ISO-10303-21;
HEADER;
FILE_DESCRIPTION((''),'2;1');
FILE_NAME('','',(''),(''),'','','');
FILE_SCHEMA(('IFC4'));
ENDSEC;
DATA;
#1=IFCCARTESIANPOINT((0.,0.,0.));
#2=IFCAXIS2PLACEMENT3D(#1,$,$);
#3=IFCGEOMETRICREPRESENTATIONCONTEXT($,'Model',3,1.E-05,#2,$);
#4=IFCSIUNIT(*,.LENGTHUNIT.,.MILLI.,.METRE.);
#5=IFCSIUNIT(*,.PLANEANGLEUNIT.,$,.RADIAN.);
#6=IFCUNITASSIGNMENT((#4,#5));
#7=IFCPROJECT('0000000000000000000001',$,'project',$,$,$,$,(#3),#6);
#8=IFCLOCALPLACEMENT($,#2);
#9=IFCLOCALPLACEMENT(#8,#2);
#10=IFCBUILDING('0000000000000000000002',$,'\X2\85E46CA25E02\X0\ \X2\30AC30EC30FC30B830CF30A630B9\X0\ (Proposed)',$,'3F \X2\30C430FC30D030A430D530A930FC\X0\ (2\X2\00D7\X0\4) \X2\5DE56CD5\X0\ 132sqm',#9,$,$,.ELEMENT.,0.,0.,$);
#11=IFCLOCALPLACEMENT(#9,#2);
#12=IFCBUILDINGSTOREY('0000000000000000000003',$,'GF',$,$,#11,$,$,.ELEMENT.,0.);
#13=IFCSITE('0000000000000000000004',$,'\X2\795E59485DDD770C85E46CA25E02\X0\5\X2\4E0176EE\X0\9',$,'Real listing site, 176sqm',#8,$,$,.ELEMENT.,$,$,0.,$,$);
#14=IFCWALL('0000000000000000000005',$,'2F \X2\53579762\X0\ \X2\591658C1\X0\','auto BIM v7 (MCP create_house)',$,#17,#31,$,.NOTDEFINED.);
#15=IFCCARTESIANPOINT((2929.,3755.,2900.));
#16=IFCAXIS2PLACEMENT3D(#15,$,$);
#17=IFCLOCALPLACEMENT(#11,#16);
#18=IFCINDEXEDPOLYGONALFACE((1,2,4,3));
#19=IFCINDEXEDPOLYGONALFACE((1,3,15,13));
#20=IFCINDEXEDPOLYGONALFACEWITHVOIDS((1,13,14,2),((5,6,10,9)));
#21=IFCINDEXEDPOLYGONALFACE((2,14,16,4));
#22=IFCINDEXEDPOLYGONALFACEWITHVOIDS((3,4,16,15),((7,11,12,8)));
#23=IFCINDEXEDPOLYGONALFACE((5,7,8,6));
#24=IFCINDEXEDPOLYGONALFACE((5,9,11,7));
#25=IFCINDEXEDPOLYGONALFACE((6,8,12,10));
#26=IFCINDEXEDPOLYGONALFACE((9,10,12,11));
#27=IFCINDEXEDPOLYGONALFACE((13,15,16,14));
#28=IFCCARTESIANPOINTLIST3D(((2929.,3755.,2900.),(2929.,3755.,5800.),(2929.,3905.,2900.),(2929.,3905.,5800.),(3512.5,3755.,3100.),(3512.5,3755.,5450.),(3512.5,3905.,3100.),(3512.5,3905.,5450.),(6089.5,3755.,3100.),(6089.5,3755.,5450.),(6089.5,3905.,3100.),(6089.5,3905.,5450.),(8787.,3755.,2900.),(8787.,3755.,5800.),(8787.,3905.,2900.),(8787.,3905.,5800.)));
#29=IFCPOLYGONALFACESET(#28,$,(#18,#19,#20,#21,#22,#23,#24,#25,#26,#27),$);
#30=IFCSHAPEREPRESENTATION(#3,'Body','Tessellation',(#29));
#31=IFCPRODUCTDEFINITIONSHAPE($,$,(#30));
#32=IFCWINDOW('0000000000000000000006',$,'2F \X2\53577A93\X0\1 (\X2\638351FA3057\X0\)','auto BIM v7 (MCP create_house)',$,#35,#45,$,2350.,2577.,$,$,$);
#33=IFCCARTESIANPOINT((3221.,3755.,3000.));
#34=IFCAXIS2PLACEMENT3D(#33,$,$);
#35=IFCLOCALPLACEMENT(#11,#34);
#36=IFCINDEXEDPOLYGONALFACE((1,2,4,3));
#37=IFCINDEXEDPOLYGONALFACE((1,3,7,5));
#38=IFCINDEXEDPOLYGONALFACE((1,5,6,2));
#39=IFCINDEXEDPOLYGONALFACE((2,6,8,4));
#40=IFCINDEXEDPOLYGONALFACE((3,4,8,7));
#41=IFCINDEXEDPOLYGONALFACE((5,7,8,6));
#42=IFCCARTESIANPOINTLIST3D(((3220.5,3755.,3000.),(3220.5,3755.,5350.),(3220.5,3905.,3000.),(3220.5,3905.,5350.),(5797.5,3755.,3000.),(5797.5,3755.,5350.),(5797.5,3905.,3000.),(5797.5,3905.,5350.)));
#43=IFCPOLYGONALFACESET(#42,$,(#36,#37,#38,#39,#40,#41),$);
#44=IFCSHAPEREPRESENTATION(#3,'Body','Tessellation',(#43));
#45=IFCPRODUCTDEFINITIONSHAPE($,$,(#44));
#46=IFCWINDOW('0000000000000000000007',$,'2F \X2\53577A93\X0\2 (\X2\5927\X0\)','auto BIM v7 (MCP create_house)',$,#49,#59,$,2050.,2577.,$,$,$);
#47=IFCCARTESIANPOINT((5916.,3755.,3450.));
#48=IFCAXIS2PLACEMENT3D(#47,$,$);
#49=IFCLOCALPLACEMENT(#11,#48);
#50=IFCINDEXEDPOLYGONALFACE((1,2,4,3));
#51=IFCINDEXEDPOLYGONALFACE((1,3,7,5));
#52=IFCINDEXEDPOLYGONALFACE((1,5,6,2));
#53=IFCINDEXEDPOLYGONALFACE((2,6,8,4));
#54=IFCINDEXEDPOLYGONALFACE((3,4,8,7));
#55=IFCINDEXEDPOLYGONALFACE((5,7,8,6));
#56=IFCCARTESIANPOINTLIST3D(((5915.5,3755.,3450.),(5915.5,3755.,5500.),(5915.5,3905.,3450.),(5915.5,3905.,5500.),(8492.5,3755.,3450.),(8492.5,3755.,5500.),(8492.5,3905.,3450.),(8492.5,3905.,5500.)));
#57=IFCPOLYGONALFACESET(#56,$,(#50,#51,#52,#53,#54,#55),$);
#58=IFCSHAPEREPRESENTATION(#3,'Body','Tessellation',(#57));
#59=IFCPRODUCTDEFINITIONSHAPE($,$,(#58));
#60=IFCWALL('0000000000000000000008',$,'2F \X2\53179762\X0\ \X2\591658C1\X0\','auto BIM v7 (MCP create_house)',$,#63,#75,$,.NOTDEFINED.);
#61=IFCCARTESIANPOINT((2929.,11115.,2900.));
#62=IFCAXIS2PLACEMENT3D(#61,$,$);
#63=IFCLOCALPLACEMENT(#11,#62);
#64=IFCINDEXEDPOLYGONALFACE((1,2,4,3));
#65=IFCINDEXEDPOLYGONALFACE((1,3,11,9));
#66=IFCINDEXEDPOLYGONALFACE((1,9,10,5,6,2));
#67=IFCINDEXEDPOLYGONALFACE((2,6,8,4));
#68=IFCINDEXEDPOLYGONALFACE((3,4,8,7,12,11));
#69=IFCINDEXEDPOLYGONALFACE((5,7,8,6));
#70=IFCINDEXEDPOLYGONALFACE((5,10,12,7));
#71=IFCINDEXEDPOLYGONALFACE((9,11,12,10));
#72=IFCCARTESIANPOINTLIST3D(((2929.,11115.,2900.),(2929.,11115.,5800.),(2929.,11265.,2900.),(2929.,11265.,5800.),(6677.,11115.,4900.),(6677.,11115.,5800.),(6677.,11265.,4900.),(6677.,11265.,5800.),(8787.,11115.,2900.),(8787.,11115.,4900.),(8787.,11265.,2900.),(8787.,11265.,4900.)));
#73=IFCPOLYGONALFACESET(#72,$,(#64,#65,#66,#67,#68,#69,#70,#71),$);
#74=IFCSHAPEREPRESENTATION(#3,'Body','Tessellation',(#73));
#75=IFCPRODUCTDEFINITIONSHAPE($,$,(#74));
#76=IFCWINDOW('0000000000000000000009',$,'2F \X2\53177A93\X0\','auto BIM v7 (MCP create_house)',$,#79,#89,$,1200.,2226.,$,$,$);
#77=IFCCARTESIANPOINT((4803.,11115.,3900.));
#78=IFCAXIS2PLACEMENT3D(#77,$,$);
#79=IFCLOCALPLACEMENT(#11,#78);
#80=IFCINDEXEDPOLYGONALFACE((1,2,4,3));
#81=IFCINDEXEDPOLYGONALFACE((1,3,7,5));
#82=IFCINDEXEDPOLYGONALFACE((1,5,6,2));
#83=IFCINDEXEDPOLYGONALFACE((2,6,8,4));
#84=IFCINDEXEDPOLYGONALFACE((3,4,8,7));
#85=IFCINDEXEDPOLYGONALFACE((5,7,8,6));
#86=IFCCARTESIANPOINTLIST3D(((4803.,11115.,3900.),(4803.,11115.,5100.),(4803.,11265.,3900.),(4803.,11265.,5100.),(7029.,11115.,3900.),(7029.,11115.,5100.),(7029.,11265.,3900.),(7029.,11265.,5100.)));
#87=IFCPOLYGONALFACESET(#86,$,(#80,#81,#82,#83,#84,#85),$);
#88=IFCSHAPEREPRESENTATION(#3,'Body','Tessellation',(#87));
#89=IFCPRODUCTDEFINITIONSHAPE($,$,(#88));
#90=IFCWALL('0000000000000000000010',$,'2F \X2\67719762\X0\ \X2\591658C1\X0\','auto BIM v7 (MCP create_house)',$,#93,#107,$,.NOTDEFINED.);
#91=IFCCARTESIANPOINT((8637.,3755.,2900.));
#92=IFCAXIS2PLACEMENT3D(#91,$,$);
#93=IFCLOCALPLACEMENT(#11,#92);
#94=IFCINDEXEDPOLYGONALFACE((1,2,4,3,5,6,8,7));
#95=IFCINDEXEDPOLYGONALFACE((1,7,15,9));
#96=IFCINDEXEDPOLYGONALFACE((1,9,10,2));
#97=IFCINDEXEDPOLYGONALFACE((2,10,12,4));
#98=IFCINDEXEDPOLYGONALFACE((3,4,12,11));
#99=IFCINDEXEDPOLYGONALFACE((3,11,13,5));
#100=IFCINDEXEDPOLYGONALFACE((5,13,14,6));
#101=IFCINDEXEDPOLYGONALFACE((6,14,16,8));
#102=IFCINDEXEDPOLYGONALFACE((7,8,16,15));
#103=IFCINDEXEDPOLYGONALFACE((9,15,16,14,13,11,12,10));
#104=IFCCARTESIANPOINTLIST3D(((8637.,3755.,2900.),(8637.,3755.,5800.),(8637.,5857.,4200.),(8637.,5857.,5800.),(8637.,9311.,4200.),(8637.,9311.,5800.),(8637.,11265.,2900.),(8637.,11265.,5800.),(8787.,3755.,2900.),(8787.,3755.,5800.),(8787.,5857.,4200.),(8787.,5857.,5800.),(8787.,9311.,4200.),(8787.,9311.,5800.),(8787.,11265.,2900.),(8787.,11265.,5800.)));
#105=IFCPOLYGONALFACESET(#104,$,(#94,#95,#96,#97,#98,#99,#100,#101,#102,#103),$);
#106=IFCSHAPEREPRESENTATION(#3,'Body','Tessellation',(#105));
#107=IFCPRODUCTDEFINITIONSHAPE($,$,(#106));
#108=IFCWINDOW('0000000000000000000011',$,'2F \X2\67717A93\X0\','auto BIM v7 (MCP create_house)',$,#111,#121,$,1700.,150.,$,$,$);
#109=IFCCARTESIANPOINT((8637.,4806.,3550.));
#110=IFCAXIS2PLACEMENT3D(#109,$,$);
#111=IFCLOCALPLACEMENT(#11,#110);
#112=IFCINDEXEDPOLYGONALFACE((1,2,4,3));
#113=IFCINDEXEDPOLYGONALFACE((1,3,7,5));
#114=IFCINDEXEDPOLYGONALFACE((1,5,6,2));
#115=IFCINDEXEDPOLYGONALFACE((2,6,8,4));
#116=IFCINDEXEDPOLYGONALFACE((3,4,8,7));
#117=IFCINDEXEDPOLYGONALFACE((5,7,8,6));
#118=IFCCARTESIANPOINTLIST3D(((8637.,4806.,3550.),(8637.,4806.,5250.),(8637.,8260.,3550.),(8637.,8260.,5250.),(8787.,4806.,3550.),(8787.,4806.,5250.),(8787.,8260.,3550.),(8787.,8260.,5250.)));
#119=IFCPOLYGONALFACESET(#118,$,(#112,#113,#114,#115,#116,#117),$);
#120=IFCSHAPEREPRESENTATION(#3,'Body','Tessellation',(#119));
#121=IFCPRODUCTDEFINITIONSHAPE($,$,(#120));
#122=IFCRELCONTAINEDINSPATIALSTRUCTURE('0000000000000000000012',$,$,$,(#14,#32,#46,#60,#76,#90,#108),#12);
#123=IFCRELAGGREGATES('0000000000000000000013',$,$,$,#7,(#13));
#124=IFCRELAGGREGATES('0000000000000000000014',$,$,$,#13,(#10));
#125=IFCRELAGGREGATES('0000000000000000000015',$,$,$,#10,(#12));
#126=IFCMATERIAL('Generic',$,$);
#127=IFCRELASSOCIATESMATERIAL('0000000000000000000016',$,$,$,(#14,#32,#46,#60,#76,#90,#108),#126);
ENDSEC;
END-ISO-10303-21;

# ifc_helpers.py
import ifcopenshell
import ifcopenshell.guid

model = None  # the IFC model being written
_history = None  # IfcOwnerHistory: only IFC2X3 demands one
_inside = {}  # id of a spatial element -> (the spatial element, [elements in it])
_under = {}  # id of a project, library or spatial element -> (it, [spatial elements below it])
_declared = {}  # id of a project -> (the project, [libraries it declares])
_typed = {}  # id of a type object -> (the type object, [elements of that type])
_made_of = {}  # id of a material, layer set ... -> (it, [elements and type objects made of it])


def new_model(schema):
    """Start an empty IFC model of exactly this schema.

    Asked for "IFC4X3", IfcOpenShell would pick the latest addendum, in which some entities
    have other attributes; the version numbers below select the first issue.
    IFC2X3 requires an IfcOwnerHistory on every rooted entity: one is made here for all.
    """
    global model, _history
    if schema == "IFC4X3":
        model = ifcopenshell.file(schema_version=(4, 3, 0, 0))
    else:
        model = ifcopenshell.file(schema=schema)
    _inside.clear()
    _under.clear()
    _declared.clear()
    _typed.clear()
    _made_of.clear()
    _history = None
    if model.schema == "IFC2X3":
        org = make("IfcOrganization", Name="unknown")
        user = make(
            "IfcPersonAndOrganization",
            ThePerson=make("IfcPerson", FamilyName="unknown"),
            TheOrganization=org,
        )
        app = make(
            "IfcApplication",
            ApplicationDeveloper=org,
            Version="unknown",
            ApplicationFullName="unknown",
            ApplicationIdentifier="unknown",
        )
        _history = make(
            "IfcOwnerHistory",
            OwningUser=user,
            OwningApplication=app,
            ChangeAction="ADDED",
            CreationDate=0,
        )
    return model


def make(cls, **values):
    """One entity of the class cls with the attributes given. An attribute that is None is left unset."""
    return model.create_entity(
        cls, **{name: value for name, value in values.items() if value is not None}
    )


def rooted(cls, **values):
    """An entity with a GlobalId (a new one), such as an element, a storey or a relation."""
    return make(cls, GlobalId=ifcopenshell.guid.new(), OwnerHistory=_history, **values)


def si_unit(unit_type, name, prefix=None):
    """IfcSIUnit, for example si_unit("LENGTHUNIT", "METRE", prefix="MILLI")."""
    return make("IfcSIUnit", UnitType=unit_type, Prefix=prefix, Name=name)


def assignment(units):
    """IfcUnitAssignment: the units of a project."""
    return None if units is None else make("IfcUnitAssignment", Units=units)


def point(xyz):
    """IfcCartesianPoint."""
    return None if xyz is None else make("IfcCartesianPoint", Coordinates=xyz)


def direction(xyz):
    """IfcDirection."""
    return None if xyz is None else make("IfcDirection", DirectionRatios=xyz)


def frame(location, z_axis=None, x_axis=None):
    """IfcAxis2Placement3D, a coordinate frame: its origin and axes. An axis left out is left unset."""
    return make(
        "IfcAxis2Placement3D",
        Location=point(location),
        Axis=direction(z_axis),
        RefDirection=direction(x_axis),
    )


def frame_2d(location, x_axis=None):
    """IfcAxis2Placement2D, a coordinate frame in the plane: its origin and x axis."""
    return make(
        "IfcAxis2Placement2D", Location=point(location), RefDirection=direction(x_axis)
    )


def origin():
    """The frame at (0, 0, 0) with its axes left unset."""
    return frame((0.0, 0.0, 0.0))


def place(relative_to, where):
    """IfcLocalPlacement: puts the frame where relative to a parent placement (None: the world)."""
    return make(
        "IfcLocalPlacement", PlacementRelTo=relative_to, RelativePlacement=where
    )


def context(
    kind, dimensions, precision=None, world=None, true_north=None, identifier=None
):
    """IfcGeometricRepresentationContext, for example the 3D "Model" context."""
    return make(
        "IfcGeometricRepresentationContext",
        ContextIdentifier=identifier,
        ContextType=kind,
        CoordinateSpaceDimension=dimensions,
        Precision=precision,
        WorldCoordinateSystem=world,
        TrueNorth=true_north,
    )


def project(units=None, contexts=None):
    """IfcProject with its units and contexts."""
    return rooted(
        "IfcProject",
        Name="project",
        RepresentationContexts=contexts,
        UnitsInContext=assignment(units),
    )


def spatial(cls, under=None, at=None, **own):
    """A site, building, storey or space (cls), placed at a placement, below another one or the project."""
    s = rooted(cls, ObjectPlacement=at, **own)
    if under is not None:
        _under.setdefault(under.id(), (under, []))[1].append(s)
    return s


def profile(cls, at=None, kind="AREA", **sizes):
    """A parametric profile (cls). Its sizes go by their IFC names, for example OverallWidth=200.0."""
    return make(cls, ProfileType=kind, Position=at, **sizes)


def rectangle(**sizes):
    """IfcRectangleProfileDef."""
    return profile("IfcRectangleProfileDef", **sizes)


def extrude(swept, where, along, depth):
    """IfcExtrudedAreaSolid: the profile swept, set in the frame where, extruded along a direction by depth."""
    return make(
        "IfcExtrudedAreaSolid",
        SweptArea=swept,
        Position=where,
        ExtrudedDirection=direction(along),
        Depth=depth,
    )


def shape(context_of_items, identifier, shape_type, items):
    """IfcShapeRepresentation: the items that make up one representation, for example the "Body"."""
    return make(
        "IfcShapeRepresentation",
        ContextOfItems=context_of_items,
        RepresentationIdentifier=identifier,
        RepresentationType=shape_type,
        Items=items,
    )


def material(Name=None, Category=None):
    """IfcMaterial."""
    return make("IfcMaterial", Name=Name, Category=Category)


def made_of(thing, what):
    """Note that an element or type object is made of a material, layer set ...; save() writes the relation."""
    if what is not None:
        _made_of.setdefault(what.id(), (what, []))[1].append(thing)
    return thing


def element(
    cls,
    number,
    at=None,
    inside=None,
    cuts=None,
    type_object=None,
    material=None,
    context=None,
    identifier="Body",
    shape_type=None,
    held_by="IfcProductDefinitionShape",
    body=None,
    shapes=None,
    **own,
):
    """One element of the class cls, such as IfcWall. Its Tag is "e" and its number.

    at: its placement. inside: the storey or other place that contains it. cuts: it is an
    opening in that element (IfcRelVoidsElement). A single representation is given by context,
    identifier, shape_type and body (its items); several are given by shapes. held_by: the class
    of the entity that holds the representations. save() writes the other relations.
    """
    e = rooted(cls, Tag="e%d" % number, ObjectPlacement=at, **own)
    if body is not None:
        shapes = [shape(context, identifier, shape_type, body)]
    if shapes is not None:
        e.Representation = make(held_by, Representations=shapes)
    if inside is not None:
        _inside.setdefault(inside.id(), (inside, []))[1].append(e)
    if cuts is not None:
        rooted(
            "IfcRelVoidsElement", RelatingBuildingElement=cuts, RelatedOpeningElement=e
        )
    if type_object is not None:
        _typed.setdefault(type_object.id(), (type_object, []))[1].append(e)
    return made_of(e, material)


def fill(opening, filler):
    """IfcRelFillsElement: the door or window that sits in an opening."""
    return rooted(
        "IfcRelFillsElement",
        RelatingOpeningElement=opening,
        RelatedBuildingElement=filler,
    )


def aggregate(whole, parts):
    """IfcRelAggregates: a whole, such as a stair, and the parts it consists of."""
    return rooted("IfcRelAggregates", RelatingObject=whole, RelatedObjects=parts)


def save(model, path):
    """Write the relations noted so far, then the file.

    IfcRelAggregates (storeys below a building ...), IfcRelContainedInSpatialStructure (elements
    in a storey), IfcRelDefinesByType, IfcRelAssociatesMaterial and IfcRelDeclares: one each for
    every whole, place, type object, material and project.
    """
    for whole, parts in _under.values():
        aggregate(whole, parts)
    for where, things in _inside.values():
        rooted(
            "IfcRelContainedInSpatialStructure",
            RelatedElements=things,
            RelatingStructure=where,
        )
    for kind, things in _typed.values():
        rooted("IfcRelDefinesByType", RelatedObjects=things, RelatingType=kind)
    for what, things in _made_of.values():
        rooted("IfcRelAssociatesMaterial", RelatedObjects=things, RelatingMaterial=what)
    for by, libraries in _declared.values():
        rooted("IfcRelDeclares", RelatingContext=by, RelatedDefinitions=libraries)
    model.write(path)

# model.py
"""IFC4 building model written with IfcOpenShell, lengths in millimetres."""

from ifc_helpers import new_model, si_unit, frame, frame_2d, origin, place, context, project, spatial, rectangle, extrude, material, element, fill, save


model = new_model("IFC4")

# Units and contexts
model_context = context("Model", 3, precision=1e-05, world=origin())
ifc_project = project(units=[si_unit("LENGTHUNIT", "METRE", prefix="MILLI"), si_unit("PLANEANGLEUNIT", "RADIAN")], contexts=[model_context])

# Site, building, storey
site_placement = place(None, origin())
site = spatial("IfcSite", under=ifc_project, at=site_placement, Name="神奈川県藤沢市5丁目9", ObjectType="Real listing site, 176sqm", CompositionType="ELEMENT", RefElevation=0.0)
building_placement = place(site_placement, origin())
building = spatial("IfcBuilding", under=site, at=building_placement, Name="藤沢市 ガレージハウス (Proposed)", ObjectType="3F ツーバイフォー (2×4) 工法 132sqm", CompositionType="ELEMENT", ElevationOfRefHeight=0.0, ElevationOfTerrain=0.0)
storey_placement = place(building_placement, origin())
storey = spatial("IfcBuildingStorey", under=building, at=storey_placement, Name="GF", CompositionType="ELEMENT", Elevation=0.0)

# Shared definitions
ifc_material = material(Name="Generic")

# Wall, openings, windows
wall_1_placement = place(storey_placement, frame((2929.0, 3755.0, 2900.0)))
wall_1 = element("IfcWall", 1, at=wall_1_placement, inside=storey, material=ifc_material, Name="2F 南面 外壁", Description="auto BIM v7 (MCP create_house)", PredefinedType="NOTDEFINED", context=model_context, shape_type="SweptSolid", body=[
    extrude(rectangle(XDim=5858.0, YDim=150.0, at=frame_2d((2929.0, 75.0))), frame((2929.0, 3755.0, 2900.0)), (0.0, 0.0, 1.0), 2900.0),
])
opening_1_placement = place(storey_placement, frame((3221.0, 3755.0, 3000.0)))
opening_1 = element("IfcOpeningElement", 2, at=opening_1_placement, cuts=wall_1, PredefinedType="NOTDEFINED", context=model_context, shape_type="SweptSolid", body=[
    extrude(rectangle(XDim=2577.0, YDim=150.0, at=frame_2d((1288.0, 75.0))), frame((3221.0, 3755.0, 3000.0)), (0.0, 0.0, 1.0), 2350.0),
])
opening_2_placement = place(storey_placement, frame((5916.0, 3755.0, 3450.0)))
opening_2 = element("IfcOpeningElement", 3, at=opening_2_placement, cuts=wall_1, PredefinedType="NOTDEFINED", context=model_context, shape_type="SweptSolid", body=[
    extrude(rectangle(XDim=2577.0, YDim=150.0, at=frame_2d((1288.0, 75.0))), frame((5916.0, 3755.0, 3450.0)), (0.0, 0.0, 1.0), 2050.0),
])
window_1_placement = place(storey_placement, frame((3221.0, 3755.0, 3000.0)))
window_1 = element("IfcWindow", 4, at=window_1_placement, inside=storey, material=ifc_material, Name="2F 南窓1 (掃出し)", Description="auto BIM v7 (MCP create_house)", OverallHeight=2350.0, OverallWidth=2577.0, context=model_context, shape_type="SweptSolid", body=[
    extrude(rectangle(XDim=2577.0, YDim=150.0, at=frame_2d((1288.0, 75.0))), frame((3221.0, 3755.0, 3000.0)), (0.0, 0.0, 1.0), 2350.0),
])
fill(opening_1, window_1)
window_2_placement = place(storey_placement, frame((5916.0, 3755.0, 3450.0)))
window_2 = element("IfcWindow", 5, at=window_2_placement, inside=storey, material=ifc_material, Name="2F 南窓2 (大)", Description="auto BIM v7 (MCP create_house)", OverallHeight=2050.0, OverallWidth=2577.0, context=model_context, shape_type="SweptSolid", body=[
    extrude(rectangle(XDim=2577.0, YDim=150.0, at=frame_2d((1288.0, 75.0))), frame((5916.0, 3755.0, 3450.0)), (0.0, 0.0, 1.0), 2050.0),
])
fill(opening_2, window_2)

# Walls, openings, windows
wall_2_placement = place(storey_placement, frame((2929.0, 11115.0, 2900.0)))
wall_2 = element("IfcWall", 6, at=wall_2_placement, inside=storey, material=ifc_material, Name="2F 北面 外壁", Description="auto BIM v7 (MCP create_house)", PredefinedType="NOTDEFINED", context=model_context, shape_type="SweptSolid", body=[
    extrude(rectangle(XDim=5858.0, YDim=150.0, at=frame_2d((2929.0, 75.0))), frame((2929.0, 11115.0, 2900.0)), (0.0, 0.0, 1.0), 2900.0),
])
opening_3_placement = place(storey_placement, frame((4803.0, 11115.0, 3900.0)))
opening_3 = element("IfcOpeningElement", 7, at=opening_3_placement, cuts=wall_2, PredefinedType="NOTDEFINED", context=model_context, shape_type="SweptSolid", body=[
    extrude(rectangle(XDim=2226.0, YDim=150.0, at=frame_2d((1113.0, 75.0))), frame((4803.0, 11115.0, 3900.0)), (0.0, 0.0, 1.0), 1200.0),
])
window_3_placement = place(storey_placement, frame((4803.0, 11115.0, 3900.0)))
window_3 = element("IfcWindow", 8, at=window_3_placement, inside=storey, material=ifc_material, Name="2F 北窓", Description="auto BIM v7 (MCP create_house)", OverallHeight=1200.0, OverallWidth=2226.0, context=model_context, shape_type="SweptSolid", body=[
    extrude(rectangle(XDim=2226.0, YDim=150.0, at=frame_2d((1113.0, 75.0))), frame((4803.0, 11115.0, 3900.0)), (0.0, 0.0, 1.0), 1200.0),
])
fill(opening_3, window_3)
wall_3_placement = place(storey_placement, frame((8637.0, 3755.0, 2900.0)))
wall_3 = element("IfcWall", 9, at=wall_3_placement, inside=storey, material=ifc_material, Name="2F 東面 外壁", Description="auto BIM v7 (MCP create_house)", PredefinedType="NOTDEFINED", context=model_context, shape_type="SweptSolid", body=[
    extrude(rectangle(XDim=150.0, YDim=7510.0, at=frame_2d((75.0, 3755.0))), frame((8637.0, 3755.0, 2900.0)), (0.0, 0.0, 1.0), 2900.0),
])
opening_4_placement = place(storey_placement, frame((8637.0, 4806.0, 3550.0)))
opening_4 = element("IfcOpeningElement", 10, at=opening_4_placement, cuts=wall_3, PredefinedType="NOTDEFINED", context=model_context, shape_type="SweptSolid", body=[
    extrude(rectangle(XDim=150.0, YDim=3454.0, at=frame_2d((75.0, 1727.0))), frame((8637.0, 4806.0, 3550.0)), (0.0, 0.0, 1.0), 1700.0),
])
window_4_placement = place(storey_placement, frame((8637.0, 4806.0, 3550.0)))
window_4 = element("IfcWindow", 11, at=window_4_placement, inside=storey, material=ifc_material, Name="2F 東窓", Description="auto BIM v7 (MCP create_house)", OverallHeight=1700.0, OverallWidth=150.0, context=model_context, shape_type="SweptSolid", body=[
    extrude(rectangle(XDim=150.0, YDim=3454.0, at=frame_2d((75.0, 1727.0))), frame((8637.0, 4806.0, 3550.0)), (0.0, 0.0, 1.0), 1700.0),
])
fill(opening_4, window_4)

save(model, "model.ifc")
